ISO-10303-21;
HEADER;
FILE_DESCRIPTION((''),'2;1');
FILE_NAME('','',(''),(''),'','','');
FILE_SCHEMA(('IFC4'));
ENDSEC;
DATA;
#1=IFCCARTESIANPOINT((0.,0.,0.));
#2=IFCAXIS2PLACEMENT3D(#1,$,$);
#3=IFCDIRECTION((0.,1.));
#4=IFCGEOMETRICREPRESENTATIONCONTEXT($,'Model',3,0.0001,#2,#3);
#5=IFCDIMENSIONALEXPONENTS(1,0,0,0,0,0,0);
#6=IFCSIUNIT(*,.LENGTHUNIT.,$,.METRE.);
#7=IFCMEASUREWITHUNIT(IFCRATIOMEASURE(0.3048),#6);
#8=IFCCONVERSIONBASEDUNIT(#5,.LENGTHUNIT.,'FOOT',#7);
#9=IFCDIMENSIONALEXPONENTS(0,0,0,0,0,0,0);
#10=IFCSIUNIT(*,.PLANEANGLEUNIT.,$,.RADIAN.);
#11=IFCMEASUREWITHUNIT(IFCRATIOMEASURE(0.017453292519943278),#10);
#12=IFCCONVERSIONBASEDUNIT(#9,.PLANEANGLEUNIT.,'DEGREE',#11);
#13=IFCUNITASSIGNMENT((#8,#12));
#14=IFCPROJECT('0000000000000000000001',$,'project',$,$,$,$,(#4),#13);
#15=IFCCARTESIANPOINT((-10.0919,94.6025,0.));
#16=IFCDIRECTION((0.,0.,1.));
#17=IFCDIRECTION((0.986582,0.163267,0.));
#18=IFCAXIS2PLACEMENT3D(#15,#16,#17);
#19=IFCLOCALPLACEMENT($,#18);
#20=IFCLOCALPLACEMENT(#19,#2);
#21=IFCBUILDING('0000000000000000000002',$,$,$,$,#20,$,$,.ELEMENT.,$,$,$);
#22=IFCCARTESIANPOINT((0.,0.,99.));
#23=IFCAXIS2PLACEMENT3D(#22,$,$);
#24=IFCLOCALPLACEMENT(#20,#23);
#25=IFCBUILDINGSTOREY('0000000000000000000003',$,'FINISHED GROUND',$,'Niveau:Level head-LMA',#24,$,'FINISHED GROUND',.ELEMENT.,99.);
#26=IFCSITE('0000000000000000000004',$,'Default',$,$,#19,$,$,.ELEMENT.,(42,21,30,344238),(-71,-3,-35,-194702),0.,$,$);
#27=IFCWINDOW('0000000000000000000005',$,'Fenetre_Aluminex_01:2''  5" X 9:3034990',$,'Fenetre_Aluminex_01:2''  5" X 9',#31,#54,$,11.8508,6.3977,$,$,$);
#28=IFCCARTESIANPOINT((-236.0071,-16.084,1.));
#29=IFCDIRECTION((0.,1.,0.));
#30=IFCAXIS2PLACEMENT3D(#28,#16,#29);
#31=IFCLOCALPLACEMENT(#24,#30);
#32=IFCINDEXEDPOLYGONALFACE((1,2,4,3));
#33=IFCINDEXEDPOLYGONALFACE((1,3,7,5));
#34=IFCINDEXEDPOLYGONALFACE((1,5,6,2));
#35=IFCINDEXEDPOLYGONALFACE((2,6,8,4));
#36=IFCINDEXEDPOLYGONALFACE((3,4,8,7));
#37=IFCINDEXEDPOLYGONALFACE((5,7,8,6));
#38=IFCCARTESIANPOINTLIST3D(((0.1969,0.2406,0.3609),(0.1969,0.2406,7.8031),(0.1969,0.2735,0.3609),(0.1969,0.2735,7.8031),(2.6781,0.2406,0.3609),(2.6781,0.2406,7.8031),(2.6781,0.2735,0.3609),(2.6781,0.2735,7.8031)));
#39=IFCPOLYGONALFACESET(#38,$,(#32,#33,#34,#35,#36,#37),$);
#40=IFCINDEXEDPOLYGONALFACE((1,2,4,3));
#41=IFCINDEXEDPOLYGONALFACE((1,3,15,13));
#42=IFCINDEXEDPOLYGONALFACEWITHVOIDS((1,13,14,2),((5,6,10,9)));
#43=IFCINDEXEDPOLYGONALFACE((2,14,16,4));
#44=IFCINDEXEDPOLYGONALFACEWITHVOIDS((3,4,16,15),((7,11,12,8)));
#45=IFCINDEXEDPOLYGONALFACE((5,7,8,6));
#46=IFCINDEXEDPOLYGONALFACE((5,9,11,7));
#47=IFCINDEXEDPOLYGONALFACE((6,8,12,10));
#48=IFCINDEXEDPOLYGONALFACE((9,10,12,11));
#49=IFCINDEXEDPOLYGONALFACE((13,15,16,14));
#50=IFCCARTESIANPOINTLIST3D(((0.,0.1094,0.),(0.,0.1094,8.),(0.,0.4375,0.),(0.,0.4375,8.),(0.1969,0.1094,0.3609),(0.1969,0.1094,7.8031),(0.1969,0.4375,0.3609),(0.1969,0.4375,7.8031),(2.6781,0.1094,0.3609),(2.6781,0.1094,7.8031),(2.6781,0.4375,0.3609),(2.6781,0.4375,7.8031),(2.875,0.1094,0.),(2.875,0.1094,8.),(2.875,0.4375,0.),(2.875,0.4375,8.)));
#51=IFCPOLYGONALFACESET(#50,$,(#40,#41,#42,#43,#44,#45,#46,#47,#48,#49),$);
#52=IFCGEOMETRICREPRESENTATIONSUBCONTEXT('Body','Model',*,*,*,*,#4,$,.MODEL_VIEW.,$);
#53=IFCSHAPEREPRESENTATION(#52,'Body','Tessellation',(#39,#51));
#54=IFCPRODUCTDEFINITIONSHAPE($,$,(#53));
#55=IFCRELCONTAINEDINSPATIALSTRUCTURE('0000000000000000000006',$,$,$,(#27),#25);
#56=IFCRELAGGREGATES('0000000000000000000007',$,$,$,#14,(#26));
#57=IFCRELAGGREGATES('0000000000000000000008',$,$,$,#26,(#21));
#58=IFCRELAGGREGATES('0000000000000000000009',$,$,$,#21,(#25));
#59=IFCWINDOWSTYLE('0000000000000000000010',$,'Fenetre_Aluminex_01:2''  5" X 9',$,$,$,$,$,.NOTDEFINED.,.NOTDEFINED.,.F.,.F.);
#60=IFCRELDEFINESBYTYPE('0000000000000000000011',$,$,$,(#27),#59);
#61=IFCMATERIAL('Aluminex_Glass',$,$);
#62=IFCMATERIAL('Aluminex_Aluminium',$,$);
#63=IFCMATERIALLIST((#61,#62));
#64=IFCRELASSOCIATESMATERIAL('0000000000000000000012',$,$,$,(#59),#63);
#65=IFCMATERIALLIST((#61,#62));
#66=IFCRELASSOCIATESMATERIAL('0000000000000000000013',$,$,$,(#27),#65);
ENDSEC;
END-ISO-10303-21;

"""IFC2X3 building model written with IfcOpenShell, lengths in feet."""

from ifc_helpers import new_model, entity, si_unit, converted_unit, direction, frame, frame_2d, origin, place, context, subcontext, project, spatial, polyline, rectangle, outline, extrude, source, transform, mapped, material, material_list, type_object, type_shapes, element, save


model = new_model("IFC2X3")

# Units and contexts
model_context = context("Model", 3, precision=0.0001, world=origin(), true_north=direction((0.0, 1.0)))
body_context = subcontext(model_context, "Body", "Model", "MODEL_VIEW")
ifc_project = project(units=[converted_unit("LENGTHUNIT", "FOOT", entity("IfcRatioMeasure", 0.3048), si_unit("LENGTHUNIT", "METRE"), dimensions=[1, 0, 0, 0, 0, 0, 0]), converted_unit("PLANEANGLEUNIT", "DEGREE", entity("IfcRatioMeasure", 0.017453292519943278), si_unit("PLANEANGLEUNIT", "RADIAN"), dimensions=[0, 0, 0, 0, 0, 0, 0])], contexts=[model_context])

# Site, building, storey
site_placement = place(None, frame((-10.0919, 94.6025, 0.0), z_axis=(0.0, 0.0, 1.0), x_axis=(0.986582, 0.163267, 0.0)))
site = spatial("IfcSite", under=ifc_project, at=site_placement, Name="Default", CompositionType="ELEMENT", RefLatitude=(42, 21, 30, 344238), RefLongitude=(-71, -3, -35, -194702), RefElevation=0.0)
building_placement = place(site_placement, origin())
building = spatial("IfcBuilding", under=site, at=building_placement, CompositionType="ELEMENT")
storey_placement = place(building_placement, frame((0.0, 0.0, 99.0)))
storey = spatial("IfcBuildingStorey", under=building, at=storey_placement, Name="FINISHED GROUND", ObjectType="Niveau:Level head-LMA", LongName="FINISHED GROUND", CompositionType="ELEMENT", Elevation=99.0)

# Window
ifc_material_1 = material(Name="Aluminex_Glass")
ifc_material_2 = material(Name="Aluminex_Aluminium")
ifc_material_list_1 = material_list([ifc_material_1, ifc_material_2])
ifc_material_list_2 = material_list([ifc_material_1, ifc_material_2])
window_style = type_object("IfcWindowStyle", Name="Fenetre_Aluminex_01:2'  5\" X 9", ConstructionType="NOTDEFINED", OperationType="NOTDEFINED", ParameterTakesPrecedence=False, Sizeable=False, material=ifc_material_list_2)
shared_shape = source(origin(), body_context, "Body", "SweptSolid", [
    extrude(rectangle(XDim=0.0328, YDim=2.4813, at=frame_2d((0.0, 0.0), x_axis=(1.0, 0.0))), frame((1.4375, 0.2571, 0.3609), z_axis=(0.0, 0.0, 1.0), x_axis=(0.0, 1.0, 0.0)), (0.0, 0.0, 1.0), 7.4423),
    extrude(outline(polyline([(-1.4375, -4.0), (1.4375, -4.0), (1.4375, 4.0), (-1.4375, 4.0), (-1.4375, -4.0)]), holes=[polyline([(-1.2406, -3.8031), (-1.2406, 3.6391), (1.2406, 3.6391), (1.2406, -3.8031), (-1.2406, -3.8031)])]), frame((1.4375, 0.1094, 4.0), z_axis=(0.0, 1.0, 0.0), x_axis=(1.0, 0.0, 0.0)), (0.0, 0.0, 1.0), 0.3281),
])
type_shapes(window_style, [shared_shape])
window_placement = place(storey_placement, frame((-236.0071, -16.084, 1.0), z_axis=(0.0, 0.0, 1.0), x_axis=(0.0, 1.0, 0.0)))
element("IfcWindow", 1, at=window_placement, inside=storey, type_object=window_style, material=ifc_material_list_1, Name="Fenetre_Aluminex_01:2'  5\" X 9:3034990", ObjectType="Fenetre_Aluminex_01:2'  5\" X 9", OverallHeight=11.8508, OverallWidth=6.3977, context=body_context, shape_type="MappedRepresentation", body=[
    mapped(shared_shape, transform((0.0, 0.0, 0.0), scale=1.0)),
])

save(model, "model.ifc")
